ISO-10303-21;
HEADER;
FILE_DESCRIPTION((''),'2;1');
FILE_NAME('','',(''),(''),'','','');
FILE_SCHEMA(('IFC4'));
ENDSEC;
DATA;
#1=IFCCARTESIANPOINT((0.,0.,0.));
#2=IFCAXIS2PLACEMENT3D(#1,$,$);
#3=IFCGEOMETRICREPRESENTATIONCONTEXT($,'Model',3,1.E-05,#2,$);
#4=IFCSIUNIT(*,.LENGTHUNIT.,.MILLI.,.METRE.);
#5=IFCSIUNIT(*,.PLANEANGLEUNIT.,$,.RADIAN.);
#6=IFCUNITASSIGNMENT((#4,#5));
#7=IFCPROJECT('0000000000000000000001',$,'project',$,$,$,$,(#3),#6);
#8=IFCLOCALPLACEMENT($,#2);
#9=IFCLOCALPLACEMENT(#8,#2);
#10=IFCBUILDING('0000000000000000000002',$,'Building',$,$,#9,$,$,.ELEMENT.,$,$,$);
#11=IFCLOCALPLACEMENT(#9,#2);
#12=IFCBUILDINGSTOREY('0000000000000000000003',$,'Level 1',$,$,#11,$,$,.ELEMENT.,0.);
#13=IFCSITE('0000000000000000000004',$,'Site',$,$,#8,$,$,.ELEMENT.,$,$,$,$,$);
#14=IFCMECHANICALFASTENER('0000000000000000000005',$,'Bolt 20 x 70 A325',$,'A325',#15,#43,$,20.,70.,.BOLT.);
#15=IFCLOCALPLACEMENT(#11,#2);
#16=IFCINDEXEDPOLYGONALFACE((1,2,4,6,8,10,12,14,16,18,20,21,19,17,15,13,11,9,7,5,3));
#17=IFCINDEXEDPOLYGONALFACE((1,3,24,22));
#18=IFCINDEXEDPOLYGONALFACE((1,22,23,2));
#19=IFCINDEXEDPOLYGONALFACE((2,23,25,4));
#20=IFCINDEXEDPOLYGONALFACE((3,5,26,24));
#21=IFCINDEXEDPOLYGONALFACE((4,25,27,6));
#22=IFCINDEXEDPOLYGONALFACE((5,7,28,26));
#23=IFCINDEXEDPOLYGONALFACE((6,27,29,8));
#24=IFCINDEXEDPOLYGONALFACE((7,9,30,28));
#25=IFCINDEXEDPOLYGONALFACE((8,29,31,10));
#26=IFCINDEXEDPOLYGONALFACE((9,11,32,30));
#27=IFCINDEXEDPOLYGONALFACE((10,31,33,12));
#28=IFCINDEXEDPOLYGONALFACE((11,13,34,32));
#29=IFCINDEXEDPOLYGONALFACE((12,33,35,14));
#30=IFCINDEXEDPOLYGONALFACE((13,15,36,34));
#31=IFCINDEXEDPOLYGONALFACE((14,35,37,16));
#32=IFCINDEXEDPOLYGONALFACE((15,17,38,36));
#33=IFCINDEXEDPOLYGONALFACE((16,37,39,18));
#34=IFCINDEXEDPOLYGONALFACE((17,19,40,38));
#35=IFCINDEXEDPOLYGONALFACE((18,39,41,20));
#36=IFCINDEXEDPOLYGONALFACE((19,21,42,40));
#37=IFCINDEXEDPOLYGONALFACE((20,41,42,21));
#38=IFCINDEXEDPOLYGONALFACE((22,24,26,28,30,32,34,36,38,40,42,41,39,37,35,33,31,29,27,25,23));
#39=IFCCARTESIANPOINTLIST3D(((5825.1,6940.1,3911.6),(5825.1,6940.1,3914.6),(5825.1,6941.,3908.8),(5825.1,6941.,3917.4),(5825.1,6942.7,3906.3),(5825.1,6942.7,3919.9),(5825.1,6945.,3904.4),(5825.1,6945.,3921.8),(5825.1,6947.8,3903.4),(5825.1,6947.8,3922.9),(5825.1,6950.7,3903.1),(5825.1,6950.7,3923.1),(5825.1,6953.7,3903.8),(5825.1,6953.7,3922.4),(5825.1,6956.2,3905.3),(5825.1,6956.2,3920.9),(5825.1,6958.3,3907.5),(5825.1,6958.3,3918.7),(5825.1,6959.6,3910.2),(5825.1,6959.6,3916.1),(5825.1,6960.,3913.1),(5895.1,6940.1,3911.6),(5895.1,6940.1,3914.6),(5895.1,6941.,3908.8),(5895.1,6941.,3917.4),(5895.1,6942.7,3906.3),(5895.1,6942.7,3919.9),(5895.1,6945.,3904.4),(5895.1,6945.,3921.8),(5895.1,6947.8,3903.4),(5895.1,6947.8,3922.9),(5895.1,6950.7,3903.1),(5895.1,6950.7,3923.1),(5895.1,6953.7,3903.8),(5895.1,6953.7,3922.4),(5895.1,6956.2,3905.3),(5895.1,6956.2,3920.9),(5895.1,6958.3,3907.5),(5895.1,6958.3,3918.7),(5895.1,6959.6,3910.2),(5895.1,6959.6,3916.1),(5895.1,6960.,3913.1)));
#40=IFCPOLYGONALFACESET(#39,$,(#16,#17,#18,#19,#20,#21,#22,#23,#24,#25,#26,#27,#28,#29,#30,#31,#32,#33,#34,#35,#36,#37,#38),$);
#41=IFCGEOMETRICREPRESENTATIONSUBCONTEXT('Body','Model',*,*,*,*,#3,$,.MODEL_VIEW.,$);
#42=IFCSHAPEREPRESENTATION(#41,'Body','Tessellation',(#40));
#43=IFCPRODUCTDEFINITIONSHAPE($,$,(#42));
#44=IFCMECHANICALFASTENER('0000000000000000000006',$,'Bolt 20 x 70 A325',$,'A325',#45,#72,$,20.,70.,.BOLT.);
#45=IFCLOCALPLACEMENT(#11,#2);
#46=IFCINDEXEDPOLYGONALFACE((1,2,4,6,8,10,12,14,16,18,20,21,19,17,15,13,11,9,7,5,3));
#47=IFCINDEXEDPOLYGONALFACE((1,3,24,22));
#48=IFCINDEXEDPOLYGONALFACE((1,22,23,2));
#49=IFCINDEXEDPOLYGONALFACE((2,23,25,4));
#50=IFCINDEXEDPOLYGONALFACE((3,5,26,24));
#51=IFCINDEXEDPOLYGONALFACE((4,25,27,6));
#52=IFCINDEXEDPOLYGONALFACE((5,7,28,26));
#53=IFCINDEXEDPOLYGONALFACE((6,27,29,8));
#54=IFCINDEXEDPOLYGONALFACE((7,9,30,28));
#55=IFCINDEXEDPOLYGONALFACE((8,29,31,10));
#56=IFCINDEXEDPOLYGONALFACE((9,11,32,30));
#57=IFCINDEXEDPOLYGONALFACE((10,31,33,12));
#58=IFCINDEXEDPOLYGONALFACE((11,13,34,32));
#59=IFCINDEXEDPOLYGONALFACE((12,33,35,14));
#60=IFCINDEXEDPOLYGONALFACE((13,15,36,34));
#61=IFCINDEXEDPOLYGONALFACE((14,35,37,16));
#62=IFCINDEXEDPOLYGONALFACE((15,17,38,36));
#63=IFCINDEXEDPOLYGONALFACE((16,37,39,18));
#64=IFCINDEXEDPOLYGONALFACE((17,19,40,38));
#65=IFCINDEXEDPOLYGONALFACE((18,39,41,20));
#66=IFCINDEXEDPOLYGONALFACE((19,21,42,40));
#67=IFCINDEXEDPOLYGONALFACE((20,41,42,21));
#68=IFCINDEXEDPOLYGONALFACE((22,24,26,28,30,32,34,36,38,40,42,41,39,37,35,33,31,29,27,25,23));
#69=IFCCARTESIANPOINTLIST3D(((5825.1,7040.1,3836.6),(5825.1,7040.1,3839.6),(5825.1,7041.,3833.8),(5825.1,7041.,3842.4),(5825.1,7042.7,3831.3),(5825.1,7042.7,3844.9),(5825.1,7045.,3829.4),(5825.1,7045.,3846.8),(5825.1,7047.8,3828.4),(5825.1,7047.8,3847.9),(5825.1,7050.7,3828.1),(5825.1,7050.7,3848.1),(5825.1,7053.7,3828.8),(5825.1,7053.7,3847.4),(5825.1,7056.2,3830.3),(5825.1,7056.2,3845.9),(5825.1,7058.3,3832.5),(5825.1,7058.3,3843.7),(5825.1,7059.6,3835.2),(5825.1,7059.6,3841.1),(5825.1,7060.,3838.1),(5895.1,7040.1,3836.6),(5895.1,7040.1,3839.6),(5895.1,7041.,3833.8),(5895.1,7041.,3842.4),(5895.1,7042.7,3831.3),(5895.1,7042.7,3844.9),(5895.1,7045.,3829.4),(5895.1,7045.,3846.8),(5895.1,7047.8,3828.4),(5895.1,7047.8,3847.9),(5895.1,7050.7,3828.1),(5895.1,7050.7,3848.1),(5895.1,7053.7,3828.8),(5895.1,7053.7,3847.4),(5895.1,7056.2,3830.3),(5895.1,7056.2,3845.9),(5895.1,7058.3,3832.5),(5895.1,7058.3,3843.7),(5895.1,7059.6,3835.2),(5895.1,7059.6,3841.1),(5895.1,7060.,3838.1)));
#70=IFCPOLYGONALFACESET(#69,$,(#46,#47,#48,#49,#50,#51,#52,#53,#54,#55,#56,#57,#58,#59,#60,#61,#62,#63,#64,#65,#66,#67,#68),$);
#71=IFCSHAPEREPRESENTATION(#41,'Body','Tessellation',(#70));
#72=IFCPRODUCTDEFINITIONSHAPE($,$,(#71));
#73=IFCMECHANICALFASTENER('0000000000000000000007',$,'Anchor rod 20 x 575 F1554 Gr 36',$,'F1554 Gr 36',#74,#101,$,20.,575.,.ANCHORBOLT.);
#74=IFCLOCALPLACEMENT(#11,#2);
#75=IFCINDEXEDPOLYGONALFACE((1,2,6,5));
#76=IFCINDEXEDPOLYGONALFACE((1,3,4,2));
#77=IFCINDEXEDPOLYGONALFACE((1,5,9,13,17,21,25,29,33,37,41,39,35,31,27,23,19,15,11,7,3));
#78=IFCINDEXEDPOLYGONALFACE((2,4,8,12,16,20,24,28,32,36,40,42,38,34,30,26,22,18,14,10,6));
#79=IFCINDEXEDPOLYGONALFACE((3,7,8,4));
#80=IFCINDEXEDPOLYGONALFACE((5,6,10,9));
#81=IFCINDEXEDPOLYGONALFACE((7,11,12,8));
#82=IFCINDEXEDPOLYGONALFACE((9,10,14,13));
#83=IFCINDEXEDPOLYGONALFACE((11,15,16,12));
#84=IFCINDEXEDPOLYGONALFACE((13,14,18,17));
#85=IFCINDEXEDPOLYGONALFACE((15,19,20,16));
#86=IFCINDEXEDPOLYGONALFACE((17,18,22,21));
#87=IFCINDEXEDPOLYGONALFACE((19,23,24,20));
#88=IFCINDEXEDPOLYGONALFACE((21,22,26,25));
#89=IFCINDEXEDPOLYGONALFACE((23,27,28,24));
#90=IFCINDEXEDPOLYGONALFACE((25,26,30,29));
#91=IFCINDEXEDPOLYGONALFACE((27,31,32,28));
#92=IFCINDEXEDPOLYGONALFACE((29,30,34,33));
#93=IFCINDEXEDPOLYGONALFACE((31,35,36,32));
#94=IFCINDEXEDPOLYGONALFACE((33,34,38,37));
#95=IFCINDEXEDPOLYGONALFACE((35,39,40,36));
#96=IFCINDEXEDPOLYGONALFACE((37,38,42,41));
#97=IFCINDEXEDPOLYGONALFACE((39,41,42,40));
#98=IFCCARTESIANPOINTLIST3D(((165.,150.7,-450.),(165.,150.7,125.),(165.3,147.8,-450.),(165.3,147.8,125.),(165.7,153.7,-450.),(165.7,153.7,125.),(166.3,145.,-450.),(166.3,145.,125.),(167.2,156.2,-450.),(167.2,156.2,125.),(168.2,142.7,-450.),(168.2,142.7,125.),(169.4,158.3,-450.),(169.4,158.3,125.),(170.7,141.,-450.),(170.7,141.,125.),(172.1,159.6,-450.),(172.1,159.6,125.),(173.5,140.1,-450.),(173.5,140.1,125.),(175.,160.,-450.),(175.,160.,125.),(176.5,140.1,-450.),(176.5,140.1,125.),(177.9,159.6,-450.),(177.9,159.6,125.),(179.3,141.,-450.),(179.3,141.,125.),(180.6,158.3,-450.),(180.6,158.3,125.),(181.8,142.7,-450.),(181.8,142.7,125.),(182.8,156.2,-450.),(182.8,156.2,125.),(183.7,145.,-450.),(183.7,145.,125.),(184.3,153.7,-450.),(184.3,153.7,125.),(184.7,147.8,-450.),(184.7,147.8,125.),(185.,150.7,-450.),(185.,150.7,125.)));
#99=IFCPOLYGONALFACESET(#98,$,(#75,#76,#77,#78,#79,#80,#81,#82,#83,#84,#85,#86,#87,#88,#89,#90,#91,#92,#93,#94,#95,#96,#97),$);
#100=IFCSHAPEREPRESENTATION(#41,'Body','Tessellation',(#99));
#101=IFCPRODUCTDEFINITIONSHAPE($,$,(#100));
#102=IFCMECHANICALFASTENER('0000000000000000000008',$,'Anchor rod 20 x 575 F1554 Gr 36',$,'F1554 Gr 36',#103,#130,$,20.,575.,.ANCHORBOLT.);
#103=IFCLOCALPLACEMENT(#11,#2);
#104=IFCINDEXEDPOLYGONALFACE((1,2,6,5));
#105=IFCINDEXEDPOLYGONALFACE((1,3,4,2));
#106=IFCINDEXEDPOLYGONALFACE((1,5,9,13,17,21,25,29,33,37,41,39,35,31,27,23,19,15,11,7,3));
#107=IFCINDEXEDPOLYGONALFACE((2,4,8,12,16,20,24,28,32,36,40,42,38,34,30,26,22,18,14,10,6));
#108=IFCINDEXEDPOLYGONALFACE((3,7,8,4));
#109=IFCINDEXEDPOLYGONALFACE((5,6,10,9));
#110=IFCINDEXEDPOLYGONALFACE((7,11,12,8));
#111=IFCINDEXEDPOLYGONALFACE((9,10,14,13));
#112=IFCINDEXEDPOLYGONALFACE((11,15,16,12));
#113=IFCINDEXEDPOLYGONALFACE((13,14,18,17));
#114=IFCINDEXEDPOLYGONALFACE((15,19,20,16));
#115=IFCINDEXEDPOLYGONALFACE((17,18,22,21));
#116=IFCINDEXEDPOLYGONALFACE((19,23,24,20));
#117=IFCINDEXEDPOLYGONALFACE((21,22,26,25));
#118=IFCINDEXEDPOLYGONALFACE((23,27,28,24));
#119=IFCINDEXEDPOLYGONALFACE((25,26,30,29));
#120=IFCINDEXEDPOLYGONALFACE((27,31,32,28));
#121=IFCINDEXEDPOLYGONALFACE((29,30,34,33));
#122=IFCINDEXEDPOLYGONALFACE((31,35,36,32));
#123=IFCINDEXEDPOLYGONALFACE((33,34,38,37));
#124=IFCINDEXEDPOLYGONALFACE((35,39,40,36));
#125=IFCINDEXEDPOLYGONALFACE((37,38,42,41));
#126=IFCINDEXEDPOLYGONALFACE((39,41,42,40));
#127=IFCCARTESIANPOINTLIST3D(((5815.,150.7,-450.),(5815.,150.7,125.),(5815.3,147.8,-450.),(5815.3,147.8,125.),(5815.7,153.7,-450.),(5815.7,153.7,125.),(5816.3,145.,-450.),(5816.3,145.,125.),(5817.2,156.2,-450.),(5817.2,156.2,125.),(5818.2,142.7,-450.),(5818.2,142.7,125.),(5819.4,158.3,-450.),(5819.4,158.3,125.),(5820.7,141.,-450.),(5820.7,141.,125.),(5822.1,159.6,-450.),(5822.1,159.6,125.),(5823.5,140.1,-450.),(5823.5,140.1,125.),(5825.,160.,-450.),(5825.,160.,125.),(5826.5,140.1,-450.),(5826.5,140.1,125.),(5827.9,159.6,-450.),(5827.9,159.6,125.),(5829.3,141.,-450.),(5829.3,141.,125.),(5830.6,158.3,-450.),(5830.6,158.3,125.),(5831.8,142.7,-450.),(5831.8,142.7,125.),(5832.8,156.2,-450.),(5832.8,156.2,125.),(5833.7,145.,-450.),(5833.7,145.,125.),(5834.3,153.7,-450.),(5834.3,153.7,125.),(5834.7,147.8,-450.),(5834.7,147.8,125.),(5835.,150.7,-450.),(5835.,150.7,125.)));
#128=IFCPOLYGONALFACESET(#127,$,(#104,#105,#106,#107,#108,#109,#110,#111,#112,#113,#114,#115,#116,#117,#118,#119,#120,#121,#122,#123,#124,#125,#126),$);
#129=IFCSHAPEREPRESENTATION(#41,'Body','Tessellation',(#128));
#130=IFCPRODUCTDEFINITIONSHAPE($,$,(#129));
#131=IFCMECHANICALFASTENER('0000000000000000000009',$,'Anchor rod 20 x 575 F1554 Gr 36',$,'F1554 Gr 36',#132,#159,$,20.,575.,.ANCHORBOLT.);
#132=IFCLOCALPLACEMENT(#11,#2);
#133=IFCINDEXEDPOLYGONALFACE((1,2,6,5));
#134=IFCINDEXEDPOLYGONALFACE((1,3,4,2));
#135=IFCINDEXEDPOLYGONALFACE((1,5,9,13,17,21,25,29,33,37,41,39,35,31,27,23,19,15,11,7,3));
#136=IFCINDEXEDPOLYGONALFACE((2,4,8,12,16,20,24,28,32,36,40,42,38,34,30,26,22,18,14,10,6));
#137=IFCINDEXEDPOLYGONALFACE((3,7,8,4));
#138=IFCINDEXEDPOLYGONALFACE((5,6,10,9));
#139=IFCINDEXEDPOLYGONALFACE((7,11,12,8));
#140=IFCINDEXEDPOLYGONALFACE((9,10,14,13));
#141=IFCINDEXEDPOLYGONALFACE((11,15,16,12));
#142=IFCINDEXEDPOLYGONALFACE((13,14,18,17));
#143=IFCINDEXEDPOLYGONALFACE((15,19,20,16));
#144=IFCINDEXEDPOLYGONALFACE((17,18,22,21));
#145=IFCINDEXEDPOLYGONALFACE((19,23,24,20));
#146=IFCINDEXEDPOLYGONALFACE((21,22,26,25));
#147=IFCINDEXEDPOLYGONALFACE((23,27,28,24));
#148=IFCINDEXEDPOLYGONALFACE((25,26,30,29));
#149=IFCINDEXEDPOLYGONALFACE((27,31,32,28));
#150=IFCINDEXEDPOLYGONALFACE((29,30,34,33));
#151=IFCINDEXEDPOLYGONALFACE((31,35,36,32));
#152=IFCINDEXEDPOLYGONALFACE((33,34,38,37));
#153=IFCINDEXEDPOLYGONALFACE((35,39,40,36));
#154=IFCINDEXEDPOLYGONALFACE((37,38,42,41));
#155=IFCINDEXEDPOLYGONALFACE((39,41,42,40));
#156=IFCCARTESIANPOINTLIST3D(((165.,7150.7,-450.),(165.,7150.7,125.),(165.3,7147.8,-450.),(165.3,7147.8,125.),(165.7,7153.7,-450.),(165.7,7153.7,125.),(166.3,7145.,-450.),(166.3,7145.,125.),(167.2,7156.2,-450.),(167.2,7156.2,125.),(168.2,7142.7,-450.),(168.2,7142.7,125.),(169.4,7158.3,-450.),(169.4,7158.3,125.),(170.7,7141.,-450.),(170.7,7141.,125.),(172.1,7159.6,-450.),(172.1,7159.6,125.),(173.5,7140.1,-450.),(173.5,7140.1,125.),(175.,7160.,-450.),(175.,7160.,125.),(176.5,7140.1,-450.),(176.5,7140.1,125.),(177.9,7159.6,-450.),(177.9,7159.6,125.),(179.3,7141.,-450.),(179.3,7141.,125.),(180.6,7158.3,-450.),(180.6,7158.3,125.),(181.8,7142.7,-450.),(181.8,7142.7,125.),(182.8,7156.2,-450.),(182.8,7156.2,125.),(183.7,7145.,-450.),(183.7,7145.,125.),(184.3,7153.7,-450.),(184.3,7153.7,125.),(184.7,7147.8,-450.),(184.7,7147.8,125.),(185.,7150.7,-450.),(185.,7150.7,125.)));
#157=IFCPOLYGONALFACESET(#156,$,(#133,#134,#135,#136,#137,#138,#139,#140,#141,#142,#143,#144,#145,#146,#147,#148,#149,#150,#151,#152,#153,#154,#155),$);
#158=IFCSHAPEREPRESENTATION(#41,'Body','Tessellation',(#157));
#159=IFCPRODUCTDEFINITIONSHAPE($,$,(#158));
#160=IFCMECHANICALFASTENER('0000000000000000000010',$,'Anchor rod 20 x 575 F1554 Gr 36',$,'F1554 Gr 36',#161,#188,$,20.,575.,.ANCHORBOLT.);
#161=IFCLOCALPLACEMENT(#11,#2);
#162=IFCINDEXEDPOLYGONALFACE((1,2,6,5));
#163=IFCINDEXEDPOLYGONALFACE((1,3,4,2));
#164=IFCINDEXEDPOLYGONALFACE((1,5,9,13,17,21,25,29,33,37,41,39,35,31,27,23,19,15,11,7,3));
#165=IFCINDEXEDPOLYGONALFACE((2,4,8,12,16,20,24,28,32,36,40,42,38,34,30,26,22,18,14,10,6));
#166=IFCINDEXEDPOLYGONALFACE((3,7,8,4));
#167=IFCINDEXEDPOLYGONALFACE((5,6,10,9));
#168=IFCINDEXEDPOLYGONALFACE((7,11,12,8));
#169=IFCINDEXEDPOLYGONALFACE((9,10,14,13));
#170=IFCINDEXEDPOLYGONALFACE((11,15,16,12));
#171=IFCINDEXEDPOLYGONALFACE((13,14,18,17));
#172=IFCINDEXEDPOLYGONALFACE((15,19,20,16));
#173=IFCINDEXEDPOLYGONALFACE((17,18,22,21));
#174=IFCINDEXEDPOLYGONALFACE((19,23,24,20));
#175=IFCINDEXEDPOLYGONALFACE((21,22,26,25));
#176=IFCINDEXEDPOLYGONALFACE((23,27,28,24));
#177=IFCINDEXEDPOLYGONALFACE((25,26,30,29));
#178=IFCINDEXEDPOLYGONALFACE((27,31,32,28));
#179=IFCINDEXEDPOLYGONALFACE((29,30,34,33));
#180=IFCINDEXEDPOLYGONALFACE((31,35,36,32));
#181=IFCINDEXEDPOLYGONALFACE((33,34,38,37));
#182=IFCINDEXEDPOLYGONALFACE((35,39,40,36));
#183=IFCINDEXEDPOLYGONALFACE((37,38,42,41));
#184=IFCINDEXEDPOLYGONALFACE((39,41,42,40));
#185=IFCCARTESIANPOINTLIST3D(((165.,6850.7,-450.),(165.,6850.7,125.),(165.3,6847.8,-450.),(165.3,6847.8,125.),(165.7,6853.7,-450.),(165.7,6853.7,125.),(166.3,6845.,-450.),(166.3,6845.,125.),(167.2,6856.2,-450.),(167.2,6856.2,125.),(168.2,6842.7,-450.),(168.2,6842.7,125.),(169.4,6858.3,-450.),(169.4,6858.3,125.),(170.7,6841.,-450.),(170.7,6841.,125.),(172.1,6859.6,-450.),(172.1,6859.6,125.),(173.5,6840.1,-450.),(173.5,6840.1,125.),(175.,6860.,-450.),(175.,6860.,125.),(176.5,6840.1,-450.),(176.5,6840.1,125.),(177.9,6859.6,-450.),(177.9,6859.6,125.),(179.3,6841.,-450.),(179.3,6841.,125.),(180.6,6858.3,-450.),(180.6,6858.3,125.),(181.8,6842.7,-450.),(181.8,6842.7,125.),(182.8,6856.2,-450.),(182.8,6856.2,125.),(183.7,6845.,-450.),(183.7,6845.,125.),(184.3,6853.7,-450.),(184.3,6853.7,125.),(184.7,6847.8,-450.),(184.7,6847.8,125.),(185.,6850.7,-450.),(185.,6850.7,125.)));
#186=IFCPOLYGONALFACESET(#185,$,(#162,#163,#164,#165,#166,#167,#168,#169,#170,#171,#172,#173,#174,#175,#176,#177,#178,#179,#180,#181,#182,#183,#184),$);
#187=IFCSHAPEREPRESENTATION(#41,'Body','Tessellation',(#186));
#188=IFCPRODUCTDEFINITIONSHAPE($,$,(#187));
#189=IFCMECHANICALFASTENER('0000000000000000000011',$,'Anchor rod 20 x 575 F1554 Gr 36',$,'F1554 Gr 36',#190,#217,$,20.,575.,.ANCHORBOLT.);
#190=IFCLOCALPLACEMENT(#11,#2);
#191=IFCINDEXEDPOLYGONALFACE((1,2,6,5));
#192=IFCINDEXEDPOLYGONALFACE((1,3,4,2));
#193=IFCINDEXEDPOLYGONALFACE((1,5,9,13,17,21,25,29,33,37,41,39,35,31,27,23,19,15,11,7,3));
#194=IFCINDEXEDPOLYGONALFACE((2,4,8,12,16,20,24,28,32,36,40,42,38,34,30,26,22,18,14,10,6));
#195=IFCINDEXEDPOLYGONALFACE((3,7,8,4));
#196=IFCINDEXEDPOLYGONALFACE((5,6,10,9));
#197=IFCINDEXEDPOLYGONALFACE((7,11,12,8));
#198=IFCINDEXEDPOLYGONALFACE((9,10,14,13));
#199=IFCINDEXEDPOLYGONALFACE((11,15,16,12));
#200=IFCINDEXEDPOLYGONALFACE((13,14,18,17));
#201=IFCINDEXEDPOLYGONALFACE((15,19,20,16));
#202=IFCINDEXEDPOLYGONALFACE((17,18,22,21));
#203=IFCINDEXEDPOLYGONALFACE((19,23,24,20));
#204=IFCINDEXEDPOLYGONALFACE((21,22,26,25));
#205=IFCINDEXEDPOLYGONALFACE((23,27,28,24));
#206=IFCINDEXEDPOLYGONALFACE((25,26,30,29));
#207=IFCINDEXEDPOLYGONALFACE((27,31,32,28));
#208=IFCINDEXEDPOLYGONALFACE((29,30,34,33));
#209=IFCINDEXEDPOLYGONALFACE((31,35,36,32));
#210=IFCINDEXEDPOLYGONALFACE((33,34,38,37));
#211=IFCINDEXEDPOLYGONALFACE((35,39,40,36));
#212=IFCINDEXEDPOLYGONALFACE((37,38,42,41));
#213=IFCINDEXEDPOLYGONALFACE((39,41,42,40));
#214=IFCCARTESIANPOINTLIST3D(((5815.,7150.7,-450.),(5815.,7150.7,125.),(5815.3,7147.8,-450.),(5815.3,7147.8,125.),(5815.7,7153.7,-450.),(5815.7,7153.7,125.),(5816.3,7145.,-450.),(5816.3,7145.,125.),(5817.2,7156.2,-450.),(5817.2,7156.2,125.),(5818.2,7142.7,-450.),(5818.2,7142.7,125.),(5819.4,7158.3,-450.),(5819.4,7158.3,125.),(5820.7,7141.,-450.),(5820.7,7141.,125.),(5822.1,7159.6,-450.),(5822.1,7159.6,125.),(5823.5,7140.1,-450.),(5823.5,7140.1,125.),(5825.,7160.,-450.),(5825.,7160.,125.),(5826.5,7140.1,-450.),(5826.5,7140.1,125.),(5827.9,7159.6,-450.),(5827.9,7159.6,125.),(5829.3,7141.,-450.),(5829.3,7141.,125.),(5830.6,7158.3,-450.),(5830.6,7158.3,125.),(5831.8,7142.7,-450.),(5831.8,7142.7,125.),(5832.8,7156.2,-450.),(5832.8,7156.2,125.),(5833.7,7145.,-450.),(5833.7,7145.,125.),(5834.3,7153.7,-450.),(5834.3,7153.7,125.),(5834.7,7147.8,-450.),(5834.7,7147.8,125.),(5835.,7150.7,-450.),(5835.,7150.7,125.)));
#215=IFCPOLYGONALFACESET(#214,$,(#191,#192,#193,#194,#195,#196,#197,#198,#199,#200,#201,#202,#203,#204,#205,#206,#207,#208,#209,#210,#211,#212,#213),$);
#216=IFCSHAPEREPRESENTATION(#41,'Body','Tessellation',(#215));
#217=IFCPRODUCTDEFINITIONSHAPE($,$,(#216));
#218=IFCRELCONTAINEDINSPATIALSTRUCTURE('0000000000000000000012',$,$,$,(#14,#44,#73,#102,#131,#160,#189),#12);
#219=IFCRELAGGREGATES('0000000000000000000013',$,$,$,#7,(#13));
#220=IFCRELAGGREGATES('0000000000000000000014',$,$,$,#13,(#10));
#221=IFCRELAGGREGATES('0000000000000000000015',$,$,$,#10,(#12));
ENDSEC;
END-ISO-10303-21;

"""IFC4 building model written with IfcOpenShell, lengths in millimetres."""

from ifc_helpers import new_model, si_unit, frame, origin, origin_2d, place, context, subcontext, project, spatial, circle, extrude, element, save


model = new_model("IFC4")

# Units and contexts
model_context = context("Model", 3, precision=1e-05, world=origin())
body_context = subcontext(model_context, "Body", "Model", "MODEL_VIEW")
ifc_project = project(units=[si_unit("LENGTHUNIT", "METRE", prefix="MILLI"), si_unit("PLANEANGLEUNIT", "RADIAN")], contexts=[model_context])

# Site, building, storey
site_placement = place(None, origin())
site = spatial("IfcSite", under=ifc_project, at=site_placement, Name="Site", CompositionType="ELEMENT")
building_placement = place(site_placement, origin())
building = spatial("IfcBuilding", under=site, at=building_placement, Name="Building", CompositionType="ELEMENT")
storey_placement = place(building_placement, origin())
storey = spatial("IfcBuildingStorey", under=building, at=storey_placement, Name="Level 1", CompositionType="ELEMENT", Elevation=0.0)

# Mechanical fasteners
for number, where, z_axis, x_axis, name in (
    (1, (5825.1, 6950.0, 3913.1), (1.0, 0.0, 0.0), (0.0, 1.0, 0.0), "Bolt 20 x 70 A325"),
    (2, (5825.1, 7050.0, 3838.1), (1.0, 0.0, 0.0), (0.0, 1.0, 0.0), "Bolt 20 x 70 A325"),
):
    element("IfcMechanicalFastener", number, at=place(storey_placement, frame(where, z_axis=z_axis, x_axis=x_axis)), inside=storey, Name=name, ObjectType="A325", NominalDiameter=20.0, NominalLength=70.0, PredefinedType="BOLT", context=body_context, shape_type="SweptSolid", body=[
        extrude(circle(Radius=10.0, at=origin_2d()), origin(), (0.0, 0.0, 1.0), 70.0),
    ])
for number, where, z_axis, x_axis, name in (
    (3, (175.0, 150.0, 125.0), (0.0, 0.0, -1.0), (0.0, 1.0, 0.0), "Anchor rod 20 x 575 F1554 Gr 36"),
    (4, (5825.0, 150.0, 125.0), (0.0, 0.0, -1.0), (0.0, 1.0, 0.0), "Anchor rod 20 x 575 F1554 Gr 36"),
    (5, (175.0, 7150.0, 125.0), (0.0, 0.0, -1.0), (0.0, 1.0, 0.0), "Anchor rod 20 x 575 F1554 Gr 36"),
    (6, (175.0, 6850.0, 125.0), (0.0, 0.0, -1.0), (0.0, 1.0, 0.0), "Anchor rod 20 x 575 F1554 Gr 36"),
    (7, (5825.0, 7150.0, 125.0), (0.0, 0.0, -1.0), (0.0, 1.0, 0.0), "Anchor rod 20 x 575 F1554 Gr 36"),
):
    element("IfcMechanicalFastener", number, at=place(storey_placement, frame(where, z_axis=z_axis, x_axis=x_axis)), inside=storey, Name=name, ObjectType="F1554 Gr 36", NominalDiameter=20.0, NominalLength=575.0, PredefinedType="ANCHORBOLT", context=body_context, shape_type="SweptSolid", body=[
        extrude(circle(Radius=10.0, at=origin_2d()), origin(), (0.0, 0.0, 1.0), 575.0),
    ])

save(model, "model.ifc")
